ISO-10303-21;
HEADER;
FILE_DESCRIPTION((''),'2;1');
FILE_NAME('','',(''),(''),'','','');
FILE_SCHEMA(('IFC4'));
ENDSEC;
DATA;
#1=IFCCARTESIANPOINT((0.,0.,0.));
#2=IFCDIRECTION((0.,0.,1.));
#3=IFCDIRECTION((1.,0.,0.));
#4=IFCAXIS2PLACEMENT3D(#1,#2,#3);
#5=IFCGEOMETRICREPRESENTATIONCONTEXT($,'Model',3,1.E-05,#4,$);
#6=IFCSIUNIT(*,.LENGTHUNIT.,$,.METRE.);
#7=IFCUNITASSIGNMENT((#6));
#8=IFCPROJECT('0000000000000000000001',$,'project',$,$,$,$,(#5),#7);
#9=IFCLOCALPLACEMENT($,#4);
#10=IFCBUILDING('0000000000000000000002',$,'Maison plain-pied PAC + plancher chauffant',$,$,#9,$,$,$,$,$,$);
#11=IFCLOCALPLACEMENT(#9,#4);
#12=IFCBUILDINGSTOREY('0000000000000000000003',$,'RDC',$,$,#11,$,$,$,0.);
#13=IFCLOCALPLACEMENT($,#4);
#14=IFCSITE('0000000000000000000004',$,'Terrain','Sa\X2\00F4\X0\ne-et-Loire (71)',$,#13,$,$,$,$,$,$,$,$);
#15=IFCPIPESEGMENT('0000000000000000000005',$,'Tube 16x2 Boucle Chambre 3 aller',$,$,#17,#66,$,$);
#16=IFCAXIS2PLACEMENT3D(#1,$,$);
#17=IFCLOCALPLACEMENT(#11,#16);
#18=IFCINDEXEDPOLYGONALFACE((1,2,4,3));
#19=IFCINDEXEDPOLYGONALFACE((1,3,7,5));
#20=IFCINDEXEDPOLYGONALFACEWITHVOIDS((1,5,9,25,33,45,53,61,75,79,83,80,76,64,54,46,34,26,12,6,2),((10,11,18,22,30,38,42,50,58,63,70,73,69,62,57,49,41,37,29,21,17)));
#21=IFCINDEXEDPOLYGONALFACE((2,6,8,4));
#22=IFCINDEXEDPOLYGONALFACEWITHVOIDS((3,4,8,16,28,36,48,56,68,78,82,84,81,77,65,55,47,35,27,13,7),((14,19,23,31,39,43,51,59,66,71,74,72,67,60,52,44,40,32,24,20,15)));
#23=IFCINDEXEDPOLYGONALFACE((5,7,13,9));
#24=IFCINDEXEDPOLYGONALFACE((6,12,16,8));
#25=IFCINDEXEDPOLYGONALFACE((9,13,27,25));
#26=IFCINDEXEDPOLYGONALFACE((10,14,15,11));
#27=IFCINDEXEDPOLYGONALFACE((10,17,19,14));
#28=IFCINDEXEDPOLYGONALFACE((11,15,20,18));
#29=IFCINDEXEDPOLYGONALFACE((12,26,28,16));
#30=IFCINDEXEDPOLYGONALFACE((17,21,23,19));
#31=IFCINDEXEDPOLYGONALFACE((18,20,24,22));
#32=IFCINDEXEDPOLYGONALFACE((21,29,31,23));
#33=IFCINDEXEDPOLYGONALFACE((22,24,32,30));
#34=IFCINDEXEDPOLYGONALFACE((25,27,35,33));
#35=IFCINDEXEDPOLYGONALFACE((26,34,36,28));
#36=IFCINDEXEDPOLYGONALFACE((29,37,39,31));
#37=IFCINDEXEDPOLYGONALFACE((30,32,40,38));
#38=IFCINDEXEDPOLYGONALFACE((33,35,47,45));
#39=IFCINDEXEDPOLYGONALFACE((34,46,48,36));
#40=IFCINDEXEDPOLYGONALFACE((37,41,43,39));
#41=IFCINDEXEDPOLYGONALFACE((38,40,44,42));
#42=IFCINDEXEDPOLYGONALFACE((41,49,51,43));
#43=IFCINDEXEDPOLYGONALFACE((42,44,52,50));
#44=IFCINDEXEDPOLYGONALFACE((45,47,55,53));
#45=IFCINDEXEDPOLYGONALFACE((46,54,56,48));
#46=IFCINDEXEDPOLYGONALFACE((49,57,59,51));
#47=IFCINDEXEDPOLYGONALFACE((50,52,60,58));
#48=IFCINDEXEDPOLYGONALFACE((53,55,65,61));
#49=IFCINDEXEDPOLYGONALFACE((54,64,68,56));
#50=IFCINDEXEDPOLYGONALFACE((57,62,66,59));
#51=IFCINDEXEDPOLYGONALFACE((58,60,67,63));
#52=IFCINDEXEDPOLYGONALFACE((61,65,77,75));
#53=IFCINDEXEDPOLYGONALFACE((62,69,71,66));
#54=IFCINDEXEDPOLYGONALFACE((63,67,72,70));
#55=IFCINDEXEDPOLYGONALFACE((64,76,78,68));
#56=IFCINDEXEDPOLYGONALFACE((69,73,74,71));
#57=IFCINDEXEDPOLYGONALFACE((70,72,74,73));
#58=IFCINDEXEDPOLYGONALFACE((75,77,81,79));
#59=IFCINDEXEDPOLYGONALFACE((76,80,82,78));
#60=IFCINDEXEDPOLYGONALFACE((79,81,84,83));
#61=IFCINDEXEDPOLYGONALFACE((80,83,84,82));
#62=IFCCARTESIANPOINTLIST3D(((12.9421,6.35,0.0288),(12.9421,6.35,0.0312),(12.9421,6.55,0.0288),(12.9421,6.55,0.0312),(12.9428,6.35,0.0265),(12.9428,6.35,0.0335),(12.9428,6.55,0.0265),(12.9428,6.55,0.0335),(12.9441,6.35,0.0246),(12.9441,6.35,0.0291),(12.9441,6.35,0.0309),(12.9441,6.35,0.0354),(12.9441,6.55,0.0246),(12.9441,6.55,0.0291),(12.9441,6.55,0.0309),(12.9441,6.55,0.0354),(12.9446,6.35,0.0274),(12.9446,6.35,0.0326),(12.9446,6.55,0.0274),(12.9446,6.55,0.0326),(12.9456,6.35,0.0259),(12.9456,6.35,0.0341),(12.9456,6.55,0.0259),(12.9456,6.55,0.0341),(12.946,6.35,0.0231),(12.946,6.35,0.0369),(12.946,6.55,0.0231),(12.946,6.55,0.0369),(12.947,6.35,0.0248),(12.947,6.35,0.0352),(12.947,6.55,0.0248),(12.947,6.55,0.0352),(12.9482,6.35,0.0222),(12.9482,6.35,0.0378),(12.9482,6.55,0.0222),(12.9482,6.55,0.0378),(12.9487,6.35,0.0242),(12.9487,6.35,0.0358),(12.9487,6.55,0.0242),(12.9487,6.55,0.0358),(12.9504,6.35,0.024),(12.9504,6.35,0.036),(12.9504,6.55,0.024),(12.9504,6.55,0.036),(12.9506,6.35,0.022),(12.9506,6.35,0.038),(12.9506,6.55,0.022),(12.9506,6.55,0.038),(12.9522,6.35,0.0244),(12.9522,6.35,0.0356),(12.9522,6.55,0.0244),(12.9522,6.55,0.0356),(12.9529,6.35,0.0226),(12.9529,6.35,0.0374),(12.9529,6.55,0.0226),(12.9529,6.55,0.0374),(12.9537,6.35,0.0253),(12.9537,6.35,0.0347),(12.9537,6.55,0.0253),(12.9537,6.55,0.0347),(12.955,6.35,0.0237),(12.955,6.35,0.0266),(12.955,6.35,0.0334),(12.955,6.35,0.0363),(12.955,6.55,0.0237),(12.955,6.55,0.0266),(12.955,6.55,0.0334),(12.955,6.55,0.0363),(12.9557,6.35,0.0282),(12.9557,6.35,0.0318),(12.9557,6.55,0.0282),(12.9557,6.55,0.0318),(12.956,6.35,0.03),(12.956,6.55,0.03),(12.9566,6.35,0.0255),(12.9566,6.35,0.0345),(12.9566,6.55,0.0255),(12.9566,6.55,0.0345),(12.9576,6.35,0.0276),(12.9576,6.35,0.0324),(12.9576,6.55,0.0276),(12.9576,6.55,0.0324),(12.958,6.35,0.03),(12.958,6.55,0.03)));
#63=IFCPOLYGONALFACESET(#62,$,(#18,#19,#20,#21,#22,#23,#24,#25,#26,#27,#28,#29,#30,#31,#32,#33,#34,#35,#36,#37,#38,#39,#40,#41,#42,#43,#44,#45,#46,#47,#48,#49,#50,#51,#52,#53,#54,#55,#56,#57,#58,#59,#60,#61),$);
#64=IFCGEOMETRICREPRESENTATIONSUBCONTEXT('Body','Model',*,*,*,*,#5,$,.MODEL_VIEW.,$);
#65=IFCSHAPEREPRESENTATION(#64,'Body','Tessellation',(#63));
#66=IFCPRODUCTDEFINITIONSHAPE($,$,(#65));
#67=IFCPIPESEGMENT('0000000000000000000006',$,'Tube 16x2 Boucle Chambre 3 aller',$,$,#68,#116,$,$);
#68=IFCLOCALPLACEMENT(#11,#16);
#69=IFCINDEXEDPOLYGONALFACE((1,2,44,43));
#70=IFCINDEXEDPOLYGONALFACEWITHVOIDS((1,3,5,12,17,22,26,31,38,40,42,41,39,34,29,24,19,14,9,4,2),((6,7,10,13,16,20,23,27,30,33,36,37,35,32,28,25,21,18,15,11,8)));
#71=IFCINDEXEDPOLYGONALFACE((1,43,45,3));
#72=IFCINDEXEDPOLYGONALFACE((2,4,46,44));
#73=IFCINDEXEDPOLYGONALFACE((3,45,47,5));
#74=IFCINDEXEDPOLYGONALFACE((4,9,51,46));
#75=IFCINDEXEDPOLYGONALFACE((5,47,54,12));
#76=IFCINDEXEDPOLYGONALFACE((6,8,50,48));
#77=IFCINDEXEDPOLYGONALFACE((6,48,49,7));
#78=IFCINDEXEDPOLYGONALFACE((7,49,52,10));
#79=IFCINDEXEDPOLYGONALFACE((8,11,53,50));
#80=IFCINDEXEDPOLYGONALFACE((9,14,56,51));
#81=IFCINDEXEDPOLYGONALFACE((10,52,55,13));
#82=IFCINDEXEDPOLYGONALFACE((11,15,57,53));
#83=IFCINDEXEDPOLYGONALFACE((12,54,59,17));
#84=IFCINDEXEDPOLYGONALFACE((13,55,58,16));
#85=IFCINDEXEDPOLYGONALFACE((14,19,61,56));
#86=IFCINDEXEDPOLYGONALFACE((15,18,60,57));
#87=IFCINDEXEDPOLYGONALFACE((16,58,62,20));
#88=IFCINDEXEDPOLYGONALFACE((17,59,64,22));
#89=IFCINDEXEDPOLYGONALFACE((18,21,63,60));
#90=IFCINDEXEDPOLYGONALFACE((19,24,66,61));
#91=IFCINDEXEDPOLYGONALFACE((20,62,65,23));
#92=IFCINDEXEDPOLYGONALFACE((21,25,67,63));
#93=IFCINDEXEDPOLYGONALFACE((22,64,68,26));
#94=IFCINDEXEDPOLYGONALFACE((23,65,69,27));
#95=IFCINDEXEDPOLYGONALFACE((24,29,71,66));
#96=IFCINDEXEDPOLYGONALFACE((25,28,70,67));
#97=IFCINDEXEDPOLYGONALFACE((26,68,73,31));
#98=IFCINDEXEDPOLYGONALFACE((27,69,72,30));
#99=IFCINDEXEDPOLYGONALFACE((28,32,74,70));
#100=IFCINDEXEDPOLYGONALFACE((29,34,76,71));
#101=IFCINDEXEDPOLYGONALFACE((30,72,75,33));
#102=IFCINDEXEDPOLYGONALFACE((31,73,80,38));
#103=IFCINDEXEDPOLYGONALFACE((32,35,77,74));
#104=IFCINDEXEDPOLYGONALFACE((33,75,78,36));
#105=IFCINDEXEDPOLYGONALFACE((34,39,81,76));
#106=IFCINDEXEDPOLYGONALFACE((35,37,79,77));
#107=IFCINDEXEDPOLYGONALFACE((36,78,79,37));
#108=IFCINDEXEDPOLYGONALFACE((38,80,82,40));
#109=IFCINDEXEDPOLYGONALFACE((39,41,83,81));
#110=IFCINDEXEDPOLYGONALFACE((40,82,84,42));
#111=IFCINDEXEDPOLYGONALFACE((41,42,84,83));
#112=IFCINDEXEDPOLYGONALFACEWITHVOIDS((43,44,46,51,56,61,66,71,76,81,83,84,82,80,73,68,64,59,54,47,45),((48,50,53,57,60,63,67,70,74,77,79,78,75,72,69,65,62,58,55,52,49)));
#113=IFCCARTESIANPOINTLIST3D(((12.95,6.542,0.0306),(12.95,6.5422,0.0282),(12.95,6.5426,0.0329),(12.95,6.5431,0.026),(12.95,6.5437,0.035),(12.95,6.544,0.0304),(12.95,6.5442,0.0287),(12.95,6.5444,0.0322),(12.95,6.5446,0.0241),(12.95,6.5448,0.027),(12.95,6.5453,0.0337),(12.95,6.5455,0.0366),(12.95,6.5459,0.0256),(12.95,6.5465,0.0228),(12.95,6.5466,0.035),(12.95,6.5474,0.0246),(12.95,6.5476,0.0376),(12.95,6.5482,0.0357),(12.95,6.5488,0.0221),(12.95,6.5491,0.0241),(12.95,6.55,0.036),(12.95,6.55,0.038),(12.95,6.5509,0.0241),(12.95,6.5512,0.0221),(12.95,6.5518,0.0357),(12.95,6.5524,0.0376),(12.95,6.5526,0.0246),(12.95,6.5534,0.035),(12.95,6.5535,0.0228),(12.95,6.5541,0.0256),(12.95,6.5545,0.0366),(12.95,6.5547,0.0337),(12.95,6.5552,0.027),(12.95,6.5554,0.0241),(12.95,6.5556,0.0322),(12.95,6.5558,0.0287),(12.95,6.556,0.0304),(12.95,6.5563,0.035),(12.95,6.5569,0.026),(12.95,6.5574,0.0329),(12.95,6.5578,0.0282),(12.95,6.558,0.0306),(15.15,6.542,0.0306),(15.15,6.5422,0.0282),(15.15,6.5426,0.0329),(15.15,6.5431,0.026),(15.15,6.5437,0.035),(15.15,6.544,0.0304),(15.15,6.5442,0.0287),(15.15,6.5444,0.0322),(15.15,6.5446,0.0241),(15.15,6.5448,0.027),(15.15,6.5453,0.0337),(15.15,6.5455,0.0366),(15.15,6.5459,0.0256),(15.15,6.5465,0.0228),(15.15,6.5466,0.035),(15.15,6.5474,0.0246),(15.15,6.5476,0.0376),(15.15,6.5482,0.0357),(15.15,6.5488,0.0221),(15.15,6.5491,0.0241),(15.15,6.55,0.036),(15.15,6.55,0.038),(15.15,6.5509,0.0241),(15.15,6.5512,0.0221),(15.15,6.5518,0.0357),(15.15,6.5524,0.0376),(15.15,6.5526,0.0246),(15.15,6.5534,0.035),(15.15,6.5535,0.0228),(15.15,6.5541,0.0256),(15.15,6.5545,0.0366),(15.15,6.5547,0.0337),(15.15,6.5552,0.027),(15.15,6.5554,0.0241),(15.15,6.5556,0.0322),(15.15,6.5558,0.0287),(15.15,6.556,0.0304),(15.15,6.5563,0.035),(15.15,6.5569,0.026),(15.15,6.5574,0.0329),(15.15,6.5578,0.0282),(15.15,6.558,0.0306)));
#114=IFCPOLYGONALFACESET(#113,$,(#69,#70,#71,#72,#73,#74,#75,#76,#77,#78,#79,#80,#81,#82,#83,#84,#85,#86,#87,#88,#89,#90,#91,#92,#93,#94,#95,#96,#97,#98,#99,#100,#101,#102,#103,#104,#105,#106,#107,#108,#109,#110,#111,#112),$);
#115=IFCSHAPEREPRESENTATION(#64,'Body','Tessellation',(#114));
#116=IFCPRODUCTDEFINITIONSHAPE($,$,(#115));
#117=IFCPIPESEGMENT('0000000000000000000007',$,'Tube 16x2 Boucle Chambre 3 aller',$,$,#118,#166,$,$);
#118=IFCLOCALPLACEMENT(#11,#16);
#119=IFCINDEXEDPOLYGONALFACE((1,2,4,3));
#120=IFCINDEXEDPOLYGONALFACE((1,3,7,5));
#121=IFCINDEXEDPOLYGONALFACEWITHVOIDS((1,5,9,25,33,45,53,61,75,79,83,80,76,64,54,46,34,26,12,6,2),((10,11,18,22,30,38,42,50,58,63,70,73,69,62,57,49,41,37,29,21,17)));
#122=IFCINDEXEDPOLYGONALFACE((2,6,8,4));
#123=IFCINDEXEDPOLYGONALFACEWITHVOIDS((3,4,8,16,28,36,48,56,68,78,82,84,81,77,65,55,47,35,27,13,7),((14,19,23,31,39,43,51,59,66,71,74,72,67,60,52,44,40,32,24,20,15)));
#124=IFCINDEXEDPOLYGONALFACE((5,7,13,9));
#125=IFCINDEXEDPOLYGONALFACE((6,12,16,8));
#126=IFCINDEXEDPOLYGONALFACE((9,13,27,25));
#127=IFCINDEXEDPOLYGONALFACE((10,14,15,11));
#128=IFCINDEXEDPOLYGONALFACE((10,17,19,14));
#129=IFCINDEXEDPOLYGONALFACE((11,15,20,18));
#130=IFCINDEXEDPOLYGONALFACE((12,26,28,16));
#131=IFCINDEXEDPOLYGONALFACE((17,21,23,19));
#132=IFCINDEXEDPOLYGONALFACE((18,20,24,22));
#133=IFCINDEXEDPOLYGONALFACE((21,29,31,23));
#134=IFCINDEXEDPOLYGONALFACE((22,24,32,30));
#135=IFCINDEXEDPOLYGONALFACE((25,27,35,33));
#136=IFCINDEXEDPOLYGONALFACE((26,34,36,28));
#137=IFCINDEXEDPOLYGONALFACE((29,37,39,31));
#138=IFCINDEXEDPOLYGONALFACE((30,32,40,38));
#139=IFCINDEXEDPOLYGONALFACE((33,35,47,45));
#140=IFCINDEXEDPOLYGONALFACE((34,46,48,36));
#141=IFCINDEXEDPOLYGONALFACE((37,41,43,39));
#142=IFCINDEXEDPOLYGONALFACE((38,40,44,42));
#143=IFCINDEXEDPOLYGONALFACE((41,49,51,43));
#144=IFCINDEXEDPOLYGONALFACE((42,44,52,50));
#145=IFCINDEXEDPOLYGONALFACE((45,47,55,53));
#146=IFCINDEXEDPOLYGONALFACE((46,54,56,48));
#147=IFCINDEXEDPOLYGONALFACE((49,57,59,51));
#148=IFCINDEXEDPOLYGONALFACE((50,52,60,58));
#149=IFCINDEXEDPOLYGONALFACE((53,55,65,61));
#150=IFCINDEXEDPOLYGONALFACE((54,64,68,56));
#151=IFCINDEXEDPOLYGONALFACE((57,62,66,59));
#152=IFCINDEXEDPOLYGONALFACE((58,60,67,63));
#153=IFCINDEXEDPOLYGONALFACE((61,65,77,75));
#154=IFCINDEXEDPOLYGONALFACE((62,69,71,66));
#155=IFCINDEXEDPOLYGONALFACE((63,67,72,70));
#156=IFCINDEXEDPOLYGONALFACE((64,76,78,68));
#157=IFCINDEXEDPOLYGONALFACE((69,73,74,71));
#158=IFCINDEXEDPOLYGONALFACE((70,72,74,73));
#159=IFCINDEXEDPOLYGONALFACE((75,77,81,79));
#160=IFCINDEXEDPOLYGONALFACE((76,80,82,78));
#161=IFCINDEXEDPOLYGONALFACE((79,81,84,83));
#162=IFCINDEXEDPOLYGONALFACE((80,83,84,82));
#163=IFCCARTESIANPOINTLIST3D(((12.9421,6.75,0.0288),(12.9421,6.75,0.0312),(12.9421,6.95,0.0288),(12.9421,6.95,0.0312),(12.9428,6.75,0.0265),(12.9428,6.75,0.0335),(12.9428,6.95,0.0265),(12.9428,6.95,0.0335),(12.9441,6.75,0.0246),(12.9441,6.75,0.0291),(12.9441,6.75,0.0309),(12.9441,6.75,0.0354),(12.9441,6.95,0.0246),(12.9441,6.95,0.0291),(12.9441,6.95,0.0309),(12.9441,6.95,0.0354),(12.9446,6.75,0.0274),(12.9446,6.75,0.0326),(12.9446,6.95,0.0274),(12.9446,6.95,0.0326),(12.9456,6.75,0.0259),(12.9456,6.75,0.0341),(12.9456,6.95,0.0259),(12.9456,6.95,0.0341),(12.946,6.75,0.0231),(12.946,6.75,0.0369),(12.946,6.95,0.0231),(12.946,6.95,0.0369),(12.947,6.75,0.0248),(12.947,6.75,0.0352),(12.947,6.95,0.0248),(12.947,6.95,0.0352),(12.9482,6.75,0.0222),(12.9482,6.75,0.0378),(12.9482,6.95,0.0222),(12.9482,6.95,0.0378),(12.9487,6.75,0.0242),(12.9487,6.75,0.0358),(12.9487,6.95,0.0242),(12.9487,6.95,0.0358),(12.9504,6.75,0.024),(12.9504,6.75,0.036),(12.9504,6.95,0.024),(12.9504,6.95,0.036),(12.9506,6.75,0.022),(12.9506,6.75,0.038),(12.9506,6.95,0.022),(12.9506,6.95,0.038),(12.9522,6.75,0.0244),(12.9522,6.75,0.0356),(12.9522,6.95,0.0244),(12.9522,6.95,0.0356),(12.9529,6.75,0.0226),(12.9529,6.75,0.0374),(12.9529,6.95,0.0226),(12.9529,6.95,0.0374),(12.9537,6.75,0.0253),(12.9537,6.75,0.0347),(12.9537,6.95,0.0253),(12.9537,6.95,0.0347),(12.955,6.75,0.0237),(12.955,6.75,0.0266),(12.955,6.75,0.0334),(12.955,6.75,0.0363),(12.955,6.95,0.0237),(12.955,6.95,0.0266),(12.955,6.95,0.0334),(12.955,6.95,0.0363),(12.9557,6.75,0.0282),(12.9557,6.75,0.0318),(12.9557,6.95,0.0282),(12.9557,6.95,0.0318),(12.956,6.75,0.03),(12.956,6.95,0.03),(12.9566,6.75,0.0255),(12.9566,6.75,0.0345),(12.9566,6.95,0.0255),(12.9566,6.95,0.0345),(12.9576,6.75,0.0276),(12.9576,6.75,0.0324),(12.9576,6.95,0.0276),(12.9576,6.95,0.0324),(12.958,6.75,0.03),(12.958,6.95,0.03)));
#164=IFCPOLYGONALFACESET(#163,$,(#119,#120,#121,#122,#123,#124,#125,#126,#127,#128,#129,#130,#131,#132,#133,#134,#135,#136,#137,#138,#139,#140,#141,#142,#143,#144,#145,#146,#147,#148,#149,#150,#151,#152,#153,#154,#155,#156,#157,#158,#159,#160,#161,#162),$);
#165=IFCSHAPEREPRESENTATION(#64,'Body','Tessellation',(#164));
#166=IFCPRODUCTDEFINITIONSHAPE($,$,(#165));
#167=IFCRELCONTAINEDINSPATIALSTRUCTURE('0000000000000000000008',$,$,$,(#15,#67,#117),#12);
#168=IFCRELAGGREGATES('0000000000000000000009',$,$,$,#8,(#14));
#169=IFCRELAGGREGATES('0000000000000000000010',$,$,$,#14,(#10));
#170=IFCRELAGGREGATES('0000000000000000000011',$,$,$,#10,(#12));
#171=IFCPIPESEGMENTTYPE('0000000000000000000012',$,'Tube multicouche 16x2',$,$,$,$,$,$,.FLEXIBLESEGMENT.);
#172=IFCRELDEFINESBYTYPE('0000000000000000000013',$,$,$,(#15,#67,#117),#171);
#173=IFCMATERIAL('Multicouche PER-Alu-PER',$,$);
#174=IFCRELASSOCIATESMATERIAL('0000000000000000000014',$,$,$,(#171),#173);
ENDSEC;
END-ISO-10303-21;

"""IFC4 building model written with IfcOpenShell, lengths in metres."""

from ifc_helpers import new_model, si_unit, frame, origin_with_axes, place, context, subcontext, project, spatial, hollow_circle, extrude, material, type_object, element, save


model = new_model("IFC4")

# Units and contexts
model_context = context("Model", 3, precision=1e-05, world=origin_with_axes())
body_context = subcontext(model_context, "Body", "Model", "MODEL_VIEW")
ifc_project = project(units=[si_unit("LENGTHUNIT", "METRE")], contexts=[model_context])

# Site, building, storey
site_placement = place(None, origin_with_axes())
site = spatial("IfcSite", under=ifc_project, at=site_placement, Name="Terrain", Description="Saône-et-Loire (71)")
building_placement = place(None, origin_with_axes())
building = spatial("IfcBuilding", under=site, at=building_placement, Name="Maison plain-pied PAC + plancher chauffant")
storey_placement = place(building_placement, origin_with_axes())
storey = spatial("IfcBuildingStorey", under=building, at=storey_placement, Name="RDC", Elevation=0.0)

# Pipe segments
ifc_material_1 = material(Name="Multicouche PER-Alu-PER")
pipe_segment_type_1 = type_object("IfcPipeSegmentType", Name="Tube multicouche 16x2", PredefinedType="FLEXIBLESEGMENT", material=ifc_material_1)
pipe_segment_1_placement = place(storey_placement, frame((12.95, 6.35, 0.03), z_axis=(0.0, 1.0, 0.0), x_axis=(1.0, 0.0, 0.0)))
element("IfcPipeSegment", 1, at=pipe_segment_1_placement, inside=storey, type_object=pipe_segment_type_1, Name="Tube 16x2 Boucle Chambre 3 aller", context=body_context, shape_type="SweptSolid", body=[
    extrude(hollow_circle(Radius=0.008, WallThickness=0.002), origin_with_axes(), (0.0, 0.0, 1.0), 0.2),
])
pipe_segment_2_placement = place(storey_placement, frame((12.95, 6.55, 0.03), z_axis=(1.0, 0.0, 0.0), x_axis=(0.0, 0.0, 1.0)))
element("IfcPipeSegment", 2, at=pipe_segment_2_placement, inside=storey, type_object=pipe_segment_type_1, Name="Tube 16x2 Boucle Chambre 3 aller", context=body_context, shape_type="SweptSolid", body=[
    extrude(hollow_circle(Radius=0.008, WallThickness=0.002), origin_with_axes(), (0.0, 0.0, 1.0), 2.2),
])
pipe_segment_3_placement = place(storey_placement, frame((12.95, 6.75, 0.03), z_axis=(0.0, 1.0, 0.0), x_axis=(1.0, 0.0, 0.0)))
element("IfcPipeSegment", 3, at=pipe_segment_3_placement, inside=storey, type_object=pipe_segment_type_1, Name="Tube 16x2 Boucle Chambre 3 aller", context=body_context, shape_type="SweptSolid", body=[
    extrude(hollow_circle(Radius=0.008, WallThickness=0.002), origin_with_axes(), (0.0, 0.0, 1.0), 0.2),
])

save(model, "model.ifc")
